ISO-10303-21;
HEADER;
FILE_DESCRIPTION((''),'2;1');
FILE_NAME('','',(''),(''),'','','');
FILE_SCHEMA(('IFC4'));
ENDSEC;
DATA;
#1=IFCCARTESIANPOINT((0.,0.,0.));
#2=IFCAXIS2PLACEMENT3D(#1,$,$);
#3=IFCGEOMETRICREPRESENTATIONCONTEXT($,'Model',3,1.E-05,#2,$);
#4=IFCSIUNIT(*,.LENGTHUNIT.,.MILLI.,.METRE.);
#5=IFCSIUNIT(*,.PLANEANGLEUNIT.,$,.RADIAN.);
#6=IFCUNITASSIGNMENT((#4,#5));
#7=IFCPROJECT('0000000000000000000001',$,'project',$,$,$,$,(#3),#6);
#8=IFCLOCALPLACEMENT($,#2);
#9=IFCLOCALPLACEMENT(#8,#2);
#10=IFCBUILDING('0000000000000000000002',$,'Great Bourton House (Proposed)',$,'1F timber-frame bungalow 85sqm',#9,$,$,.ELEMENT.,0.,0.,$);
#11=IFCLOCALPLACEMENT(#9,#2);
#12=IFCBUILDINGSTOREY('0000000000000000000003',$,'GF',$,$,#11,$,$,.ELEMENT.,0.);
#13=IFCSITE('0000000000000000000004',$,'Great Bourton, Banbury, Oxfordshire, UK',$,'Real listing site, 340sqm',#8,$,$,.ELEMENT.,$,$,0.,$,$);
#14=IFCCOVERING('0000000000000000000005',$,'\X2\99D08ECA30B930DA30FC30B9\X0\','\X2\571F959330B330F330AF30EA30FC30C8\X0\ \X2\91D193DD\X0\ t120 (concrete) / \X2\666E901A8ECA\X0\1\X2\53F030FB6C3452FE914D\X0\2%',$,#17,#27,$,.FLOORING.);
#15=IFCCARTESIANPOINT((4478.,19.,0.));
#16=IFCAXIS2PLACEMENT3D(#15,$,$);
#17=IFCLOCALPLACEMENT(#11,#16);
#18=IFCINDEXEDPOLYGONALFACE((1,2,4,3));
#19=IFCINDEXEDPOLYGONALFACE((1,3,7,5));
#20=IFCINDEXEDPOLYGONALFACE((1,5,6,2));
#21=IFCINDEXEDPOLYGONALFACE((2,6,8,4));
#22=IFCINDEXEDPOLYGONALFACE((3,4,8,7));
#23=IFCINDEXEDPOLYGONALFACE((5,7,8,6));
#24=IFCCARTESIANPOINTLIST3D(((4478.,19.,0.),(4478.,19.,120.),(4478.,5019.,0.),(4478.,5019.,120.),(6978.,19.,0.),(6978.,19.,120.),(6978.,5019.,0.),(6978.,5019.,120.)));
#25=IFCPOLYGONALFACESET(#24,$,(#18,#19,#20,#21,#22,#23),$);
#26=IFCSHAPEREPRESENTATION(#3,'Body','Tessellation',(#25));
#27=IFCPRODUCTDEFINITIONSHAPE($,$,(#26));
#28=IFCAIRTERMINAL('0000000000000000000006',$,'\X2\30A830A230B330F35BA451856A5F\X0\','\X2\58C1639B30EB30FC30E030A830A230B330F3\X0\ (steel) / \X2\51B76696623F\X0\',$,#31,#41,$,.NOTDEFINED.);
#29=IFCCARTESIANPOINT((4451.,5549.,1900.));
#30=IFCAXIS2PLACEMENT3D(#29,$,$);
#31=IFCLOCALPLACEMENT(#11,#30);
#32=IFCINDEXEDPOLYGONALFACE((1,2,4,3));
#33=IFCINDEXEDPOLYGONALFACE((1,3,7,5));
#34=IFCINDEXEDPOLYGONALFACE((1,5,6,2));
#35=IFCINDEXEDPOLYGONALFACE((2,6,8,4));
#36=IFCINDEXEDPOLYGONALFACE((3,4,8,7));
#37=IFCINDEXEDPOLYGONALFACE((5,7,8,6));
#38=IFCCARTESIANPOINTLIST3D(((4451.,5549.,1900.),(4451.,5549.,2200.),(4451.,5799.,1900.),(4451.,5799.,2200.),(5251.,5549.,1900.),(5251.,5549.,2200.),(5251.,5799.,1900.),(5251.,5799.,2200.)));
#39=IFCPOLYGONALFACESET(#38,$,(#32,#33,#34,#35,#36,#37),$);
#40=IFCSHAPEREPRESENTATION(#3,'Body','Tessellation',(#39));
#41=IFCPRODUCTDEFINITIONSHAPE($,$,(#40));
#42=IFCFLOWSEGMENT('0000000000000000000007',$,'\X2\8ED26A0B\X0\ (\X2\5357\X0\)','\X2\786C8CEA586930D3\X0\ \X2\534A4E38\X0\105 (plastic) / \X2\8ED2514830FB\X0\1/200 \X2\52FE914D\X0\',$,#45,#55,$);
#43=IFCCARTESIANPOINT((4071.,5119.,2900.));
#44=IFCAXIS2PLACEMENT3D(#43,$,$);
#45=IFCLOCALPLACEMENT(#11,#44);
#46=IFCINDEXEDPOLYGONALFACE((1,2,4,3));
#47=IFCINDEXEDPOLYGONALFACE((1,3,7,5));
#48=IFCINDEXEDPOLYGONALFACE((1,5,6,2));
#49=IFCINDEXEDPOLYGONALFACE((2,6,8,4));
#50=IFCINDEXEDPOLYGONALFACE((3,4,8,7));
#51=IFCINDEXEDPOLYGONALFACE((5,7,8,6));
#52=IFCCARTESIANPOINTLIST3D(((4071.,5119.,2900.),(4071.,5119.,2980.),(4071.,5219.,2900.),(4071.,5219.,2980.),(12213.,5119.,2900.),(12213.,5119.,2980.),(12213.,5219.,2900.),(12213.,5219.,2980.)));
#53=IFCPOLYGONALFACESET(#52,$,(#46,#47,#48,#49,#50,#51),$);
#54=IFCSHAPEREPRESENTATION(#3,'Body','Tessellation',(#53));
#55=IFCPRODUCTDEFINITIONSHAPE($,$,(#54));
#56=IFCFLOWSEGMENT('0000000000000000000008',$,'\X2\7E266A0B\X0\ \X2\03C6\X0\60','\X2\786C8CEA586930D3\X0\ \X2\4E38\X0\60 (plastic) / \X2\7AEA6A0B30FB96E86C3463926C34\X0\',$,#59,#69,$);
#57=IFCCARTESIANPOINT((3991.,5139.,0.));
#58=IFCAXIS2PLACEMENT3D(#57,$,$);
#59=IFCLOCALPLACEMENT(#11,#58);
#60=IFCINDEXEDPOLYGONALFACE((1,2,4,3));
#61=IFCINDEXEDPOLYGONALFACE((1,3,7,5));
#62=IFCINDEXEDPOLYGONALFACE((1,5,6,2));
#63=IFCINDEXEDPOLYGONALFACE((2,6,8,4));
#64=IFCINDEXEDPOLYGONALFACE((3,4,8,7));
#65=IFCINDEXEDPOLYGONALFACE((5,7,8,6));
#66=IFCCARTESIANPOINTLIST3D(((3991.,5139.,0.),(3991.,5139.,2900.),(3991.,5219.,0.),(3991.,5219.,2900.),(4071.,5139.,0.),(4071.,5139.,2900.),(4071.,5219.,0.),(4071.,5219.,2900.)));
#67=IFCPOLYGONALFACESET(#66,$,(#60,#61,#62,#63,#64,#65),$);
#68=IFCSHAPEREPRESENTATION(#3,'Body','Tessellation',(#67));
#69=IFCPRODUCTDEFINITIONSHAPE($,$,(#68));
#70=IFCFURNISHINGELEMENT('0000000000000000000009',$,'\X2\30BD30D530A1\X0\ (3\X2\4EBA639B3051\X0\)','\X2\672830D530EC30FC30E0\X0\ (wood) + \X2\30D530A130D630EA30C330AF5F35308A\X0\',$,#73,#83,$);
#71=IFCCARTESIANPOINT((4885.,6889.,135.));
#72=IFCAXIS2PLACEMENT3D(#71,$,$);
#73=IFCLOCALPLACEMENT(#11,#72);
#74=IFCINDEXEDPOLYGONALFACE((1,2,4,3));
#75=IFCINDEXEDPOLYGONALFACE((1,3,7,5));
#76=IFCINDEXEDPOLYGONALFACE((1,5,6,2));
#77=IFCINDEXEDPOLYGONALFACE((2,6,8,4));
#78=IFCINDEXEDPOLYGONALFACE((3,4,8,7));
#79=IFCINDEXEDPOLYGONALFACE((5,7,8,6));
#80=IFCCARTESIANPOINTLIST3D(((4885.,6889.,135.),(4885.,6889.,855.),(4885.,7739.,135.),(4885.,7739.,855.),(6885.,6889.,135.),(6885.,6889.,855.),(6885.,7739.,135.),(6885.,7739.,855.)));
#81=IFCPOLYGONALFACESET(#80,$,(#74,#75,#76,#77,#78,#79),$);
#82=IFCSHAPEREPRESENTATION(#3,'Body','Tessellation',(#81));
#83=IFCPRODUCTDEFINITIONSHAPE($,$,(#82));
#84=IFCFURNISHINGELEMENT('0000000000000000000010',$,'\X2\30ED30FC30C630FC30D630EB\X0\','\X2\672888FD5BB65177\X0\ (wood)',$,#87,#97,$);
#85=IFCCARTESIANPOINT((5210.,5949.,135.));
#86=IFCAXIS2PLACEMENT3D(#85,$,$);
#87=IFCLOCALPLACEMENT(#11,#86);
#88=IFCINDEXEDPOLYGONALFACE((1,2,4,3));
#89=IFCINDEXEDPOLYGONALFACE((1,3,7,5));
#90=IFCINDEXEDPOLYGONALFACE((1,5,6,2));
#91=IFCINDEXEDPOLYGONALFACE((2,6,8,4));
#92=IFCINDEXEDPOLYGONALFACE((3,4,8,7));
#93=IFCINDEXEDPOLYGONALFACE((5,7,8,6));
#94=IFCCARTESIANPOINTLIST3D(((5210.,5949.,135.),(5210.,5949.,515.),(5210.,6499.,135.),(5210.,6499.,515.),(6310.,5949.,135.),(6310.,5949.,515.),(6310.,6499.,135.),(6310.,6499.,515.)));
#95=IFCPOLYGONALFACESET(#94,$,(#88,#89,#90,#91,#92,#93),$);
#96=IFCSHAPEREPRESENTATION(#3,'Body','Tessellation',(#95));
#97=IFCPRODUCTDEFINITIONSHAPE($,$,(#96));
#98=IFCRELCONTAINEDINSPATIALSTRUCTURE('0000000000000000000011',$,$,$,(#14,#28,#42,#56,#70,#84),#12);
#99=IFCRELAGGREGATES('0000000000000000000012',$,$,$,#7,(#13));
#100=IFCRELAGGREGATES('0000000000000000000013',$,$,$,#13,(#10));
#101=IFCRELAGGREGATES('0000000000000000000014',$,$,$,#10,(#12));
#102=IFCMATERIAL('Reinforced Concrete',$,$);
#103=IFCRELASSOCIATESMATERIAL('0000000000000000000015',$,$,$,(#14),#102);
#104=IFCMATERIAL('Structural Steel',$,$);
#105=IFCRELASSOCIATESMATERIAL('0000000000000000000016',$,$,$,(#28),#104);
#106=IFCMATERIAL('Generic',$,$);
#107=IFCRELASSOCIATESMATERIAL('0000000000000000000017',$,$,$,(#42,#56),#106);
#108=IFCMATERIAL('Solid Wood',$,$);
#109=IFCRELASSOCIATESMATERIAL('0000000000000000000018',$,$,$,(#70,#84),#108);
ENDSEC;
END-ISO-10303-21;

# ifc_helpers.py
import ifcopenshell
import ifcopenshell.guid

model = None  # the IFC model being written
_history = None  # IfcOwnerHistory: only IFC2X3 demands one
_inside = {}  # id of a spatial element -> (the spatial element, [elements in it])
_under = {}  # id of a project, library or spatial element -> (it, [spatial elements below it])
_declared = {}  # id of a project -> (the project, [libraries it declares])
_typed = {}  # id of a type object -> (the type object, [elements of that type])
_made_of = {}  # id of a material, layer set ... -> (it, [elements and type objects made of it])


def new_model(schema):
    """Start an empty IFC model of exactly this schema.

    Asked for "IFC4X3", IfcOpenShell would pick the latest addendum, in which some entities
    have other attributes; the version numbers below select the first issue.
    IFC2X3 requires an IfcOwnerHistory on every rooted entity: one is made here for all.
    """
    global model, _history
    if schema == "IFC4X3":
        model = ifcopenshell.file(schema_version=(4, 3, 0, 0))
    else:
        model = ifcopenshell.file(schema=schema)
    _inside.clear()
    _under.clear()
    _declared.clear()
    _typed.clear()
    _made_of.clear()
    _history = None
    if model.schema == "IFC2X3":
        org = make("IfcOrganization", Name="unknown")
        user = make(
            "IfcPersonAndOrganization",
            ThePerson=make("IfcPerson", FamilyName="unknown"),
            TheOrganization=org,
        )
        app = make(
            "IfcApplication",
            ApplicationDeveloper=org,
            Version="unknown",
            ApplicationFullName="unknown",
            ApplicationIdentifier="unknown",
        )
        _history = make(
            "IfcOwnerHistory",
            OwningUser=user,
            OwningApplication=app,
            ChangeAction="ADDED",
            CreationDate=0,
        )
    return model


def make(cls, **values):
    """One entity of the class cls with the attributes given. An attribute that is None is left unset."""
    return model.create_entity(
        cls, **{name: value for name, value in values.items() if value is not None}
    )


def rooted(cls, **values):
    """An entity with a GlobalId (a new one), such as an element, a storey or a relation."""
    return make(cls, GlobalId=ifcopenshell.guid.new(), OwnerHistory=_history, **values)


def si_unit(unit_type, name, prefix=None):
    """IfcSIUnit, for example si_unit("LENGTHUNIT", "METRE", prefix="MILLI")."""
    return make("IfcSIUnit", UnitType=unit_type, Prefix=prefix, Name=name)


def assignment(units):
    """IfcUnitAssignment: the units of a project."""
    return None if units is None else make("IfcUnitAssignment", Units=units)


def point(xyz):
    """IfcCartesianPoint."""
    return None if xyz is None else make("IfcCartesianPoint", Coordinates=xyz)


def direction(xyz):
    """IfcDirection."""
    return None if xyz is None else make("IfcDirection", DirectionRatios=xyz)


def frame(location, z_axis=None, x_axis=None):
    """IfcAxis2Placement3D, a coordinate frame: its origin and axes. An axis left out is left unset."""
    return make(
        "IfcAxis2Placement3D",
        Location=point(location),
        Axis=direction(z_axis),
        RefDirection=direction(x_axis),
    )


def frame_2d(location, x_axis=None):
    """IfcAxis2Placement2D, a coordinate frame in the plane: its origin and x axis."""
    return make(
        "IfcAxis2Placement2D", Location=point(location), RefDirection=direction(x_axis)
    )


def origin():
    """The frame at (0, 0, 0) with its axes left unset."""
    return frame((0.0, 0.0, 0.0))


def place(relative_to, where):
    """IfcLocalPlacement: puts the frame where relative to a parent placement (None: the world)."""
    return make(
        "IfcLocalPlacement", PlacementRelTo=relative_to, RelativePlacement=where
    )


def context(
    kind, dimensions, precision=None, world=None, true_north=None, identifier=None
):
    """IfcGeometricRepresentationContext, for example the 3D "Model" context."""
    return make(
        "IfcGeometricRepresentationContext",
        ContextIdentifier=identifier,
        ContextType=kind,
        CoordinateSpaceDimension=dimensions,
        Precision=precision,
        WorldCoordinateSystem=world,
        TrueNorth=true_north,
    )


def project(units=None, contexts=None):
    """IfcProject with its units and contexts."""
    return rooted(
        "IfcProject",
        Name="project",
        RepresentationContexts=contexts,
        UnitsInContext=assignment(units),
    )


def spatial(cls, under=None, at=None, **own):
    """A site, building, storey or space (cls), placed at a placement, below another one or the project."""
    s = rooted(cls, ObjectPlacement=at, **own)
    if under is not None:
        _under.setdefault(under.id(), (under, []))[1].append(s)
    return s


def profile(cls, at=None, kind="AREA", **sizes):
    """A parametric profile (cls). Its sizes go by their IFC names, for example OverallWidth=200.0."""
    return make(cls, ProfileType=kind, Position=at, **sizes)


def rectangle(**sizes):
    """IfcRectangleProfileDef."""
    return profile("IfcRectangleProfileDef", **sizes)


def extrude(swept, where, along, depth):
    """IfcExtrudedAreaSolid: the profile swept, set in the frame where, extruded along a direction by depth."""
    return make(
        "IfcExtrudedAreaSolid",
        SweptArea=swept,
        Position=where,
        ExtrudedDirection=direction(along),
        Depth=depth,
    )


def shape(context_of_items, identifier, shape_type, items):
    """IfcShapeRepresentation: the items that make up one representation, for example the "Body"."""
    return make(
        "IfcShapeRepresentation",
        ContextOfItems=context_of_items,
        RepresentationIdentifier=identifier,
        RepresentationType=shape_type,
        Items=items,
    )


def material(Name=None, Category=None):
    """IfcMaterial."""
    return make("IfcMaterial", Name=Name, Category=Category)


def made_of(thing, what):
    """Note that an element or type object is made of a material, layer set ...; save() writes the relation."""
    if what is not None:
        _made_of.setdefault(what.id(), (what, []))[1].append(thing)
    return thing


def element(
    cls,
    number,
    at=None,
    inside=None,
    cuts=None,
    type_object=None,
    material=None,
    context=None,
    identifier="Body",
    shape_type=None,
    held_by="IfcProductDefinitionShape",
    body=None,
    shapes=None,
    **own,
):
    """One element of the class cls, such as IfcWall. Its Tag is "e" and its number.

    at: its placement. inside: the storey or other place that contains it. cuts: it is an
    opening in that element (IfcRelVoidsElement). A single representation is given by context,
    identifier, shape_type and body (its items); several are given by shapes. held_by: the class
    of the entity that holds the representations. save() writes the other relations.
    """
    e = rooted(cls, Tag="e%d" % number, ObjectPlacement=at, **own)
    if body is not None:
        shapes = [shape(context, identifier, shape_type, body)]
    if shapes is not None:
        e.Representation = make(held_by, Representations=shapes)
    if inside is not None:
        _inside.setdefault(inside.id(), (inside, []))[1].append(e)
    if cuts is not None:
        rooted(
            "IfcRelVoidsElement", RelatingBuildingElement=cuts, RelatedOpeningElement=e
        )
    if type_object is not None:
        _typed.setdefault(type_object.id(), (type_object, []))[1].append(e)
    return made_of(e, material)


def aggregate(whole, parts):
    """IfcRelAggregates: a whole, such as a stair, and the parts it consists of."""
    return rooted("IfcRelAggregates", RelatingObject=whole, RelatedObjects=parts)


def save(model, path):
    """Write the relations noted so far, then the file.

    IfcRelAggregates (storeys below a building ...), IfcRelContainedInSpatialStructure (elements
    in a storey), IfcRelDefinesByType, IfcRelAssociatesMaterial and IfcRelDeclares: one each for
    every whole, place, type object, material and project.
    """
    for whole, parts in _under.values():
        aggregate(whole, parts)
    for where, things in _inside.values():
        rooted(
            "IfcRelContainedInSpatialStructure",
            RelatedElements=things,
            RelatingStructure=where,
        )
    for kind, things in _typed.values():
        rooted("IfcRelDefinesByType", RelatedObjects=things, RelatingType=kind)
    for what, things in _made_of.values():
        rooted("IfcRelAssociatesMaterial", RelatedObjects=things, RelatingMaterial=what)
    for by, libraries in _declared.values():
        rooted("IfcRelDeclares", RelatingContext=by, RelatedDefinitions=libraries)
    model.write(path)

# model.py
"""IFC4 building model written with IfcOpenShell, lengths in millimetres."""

from ifc_helpers import new_model, si_unit, frame, frame_2d, origin, place, context, project, spatial, rectangle, extrude, material, element, save


model = new_model("IFC4")

# Units and contexts
model_context = context("Model", 3, precision=1e-05, world=origin())
ifc_project = project(units=[si_unit("LENGTHUNIT", "METRE", prefix="MILLI"), si_unit("PLANEANGLEUNIT", "RADIAN")], contexts=[model_context])

# Site, building, storey
site_placement = place(None, origin())
site = spatial("IfcSite", under=ifc_project, at=site_placement, Name="Great Bourton, Banbury, Oxfordshire, UK", ObjectType="Real listing site, 340sqm", CompositionType="ELEMENT", RefElevation=0.0)
building_placement = place(site_placement, origin())
building = spatial("IfcBuilding", under=site, at=building_placement, Name="Great Bourton House (Proposed)", ObjectType="1F timber-frame bungalow 85sqm", CompositionType="ELEMENT", ElevationOfRefHeight=0.0, ElevationOfTerrain=0.0)
storey_placement = place(building_placement, origin())
storey = spatial("IfcBuildingStorey", under=building, at=storey_placement, Name="GF", CompositionType="ELEMENT", Elevation=0.0)

# Shared definitions
ifc_material_1 = material(Name="Solid Wood")

# Shared definitions
ifc_material_2 = material(Name="Reinforced Concrete")

# Shared definitions
ifc_material_3 = material(Name="Structural Steel")

# Covering
ifc_material_4 = material(Name="Generic")
covering_1_placement = place(storey_placement, frame((4478.0, 19.0, 0.0)))
element("IfcCovering", 1, at=covering_1_placement, inside=storey, material=ifc_material_2, Name="駐車スペース", Description="土間コンクリート 金鏝 t120 (concrete) / 普通車1台・水勾配2%", PredefinedType="FLOORING", context=model_context, shape_type="SweptSolid", body=[
    extrude(rectangle(XDim=2500.0, YDim=5000.0, at=frame_2d((1250.0, 2500.0))), frame((4478.0, 19.0, 0.0)), (0.0, 0.0, 1.0), 120.0),
])

# Air terminal
air_terminal_placement = place(storey_placement, frame((4451.0, 5549.0, 1900.0)))
element("IfcAirTerminal", 2, at=air_terminal_placement, inside=storey, material=ifc_material_3, Name="エアコン室内機", Description="壁掛ルームエアコン (steel) / 冷暖房", PredefinedType="NOTDEFINED", context=model_context, shape_type="SweptSolid", body=[
    extrude(rectangle(XDim=800.0, YDim=250.0, at=frame_2d((400.0, 125.0))), frame((4451.0, 5549.0, 1900.0)), (0.0, 0.0, 1.0), 300.0),
])

# Flow segments
flow_segment_1_placement = place(storey_placement, frame((4071.0, 5119.0, 2900.0)))
element("IfcFlowSegment", 3, at=flow_segment_1_placement, inside=storey, material=ifc_material_4, Name="軒樋 (南)", Description="硬質塩ビ 半丸105 (plastic) / 軒先・1/200 勾配", context=model_context, shape_type="SweptSolid", body=[
    extrude(rectangle(XDim=8142.0, YDim=100.0, at=frame_2d((4071.0, 50.0))), frame((4071.0, 5119.0, 2900.0)), (0.0, 0.0, 1.0), 80.0),
])
flow_segment_2_placement = place(storey_placement, frame((3991.0, 5139.0, 0.0)))
element("IfcFlowSegment", 4, at=flow_segment_2_placement, inside=storey, material=ifc_material_4, Name="縦樋 φ60", Description="硬質塩ビ 丸60 (plastic) / 竪樋・雨水排水", context=model_context, shape_type="SweptSolid", body=[
    extrude(rectangle(XDim=80.0, YDim=80.0, at=frame_2d((40.0, 40.0))), frame((3991.0, 5139.0, 0.0)), (0.0, 0.0, 1.0), 2900.0),
])

# Furnishing elements
furnishing_1_placement = place(storey_placement, frame((4885.0, 6889.0, 135.0)))
element("IfcFurnishingElement", 5, at=furnishing_1_placement, inside=storey, material=ifc_material_1, Name="ソファ (3人掛け)", Description="木フレーム (wood) + ファブリック張り", context=model_context, shape_type="SweptSolid", body=[
    extrude(rectangle(XDim=2000.0, YDim=850.0, at=frame_2d((1000.0, 425.0))), frame((4885.0, 6889.0, 135.0)), (0.0, 0.0, 1.0), 720.0),
])
furnishing_2_placement = place(storey_placement, frame((5210.0, 5949.0, 135.0)))
element("IfcFurnishingElement", 6, at=furnishing_2_placement, inside=storey, material=ifc_material_1, Name="ローテーブル", Description="木製家具 (wood)", context=model_context, shape_type="SweptSolid", body=[
    extrude(rectangle(XDim=1100.0, YDim=550.0, at=frame_2d((550.0, 275.0))), frame((5210.0, 5949.0, 135.0)), (0.0, 0.0, 1.0), 380.0),
])

save(model, "model.ifc")
